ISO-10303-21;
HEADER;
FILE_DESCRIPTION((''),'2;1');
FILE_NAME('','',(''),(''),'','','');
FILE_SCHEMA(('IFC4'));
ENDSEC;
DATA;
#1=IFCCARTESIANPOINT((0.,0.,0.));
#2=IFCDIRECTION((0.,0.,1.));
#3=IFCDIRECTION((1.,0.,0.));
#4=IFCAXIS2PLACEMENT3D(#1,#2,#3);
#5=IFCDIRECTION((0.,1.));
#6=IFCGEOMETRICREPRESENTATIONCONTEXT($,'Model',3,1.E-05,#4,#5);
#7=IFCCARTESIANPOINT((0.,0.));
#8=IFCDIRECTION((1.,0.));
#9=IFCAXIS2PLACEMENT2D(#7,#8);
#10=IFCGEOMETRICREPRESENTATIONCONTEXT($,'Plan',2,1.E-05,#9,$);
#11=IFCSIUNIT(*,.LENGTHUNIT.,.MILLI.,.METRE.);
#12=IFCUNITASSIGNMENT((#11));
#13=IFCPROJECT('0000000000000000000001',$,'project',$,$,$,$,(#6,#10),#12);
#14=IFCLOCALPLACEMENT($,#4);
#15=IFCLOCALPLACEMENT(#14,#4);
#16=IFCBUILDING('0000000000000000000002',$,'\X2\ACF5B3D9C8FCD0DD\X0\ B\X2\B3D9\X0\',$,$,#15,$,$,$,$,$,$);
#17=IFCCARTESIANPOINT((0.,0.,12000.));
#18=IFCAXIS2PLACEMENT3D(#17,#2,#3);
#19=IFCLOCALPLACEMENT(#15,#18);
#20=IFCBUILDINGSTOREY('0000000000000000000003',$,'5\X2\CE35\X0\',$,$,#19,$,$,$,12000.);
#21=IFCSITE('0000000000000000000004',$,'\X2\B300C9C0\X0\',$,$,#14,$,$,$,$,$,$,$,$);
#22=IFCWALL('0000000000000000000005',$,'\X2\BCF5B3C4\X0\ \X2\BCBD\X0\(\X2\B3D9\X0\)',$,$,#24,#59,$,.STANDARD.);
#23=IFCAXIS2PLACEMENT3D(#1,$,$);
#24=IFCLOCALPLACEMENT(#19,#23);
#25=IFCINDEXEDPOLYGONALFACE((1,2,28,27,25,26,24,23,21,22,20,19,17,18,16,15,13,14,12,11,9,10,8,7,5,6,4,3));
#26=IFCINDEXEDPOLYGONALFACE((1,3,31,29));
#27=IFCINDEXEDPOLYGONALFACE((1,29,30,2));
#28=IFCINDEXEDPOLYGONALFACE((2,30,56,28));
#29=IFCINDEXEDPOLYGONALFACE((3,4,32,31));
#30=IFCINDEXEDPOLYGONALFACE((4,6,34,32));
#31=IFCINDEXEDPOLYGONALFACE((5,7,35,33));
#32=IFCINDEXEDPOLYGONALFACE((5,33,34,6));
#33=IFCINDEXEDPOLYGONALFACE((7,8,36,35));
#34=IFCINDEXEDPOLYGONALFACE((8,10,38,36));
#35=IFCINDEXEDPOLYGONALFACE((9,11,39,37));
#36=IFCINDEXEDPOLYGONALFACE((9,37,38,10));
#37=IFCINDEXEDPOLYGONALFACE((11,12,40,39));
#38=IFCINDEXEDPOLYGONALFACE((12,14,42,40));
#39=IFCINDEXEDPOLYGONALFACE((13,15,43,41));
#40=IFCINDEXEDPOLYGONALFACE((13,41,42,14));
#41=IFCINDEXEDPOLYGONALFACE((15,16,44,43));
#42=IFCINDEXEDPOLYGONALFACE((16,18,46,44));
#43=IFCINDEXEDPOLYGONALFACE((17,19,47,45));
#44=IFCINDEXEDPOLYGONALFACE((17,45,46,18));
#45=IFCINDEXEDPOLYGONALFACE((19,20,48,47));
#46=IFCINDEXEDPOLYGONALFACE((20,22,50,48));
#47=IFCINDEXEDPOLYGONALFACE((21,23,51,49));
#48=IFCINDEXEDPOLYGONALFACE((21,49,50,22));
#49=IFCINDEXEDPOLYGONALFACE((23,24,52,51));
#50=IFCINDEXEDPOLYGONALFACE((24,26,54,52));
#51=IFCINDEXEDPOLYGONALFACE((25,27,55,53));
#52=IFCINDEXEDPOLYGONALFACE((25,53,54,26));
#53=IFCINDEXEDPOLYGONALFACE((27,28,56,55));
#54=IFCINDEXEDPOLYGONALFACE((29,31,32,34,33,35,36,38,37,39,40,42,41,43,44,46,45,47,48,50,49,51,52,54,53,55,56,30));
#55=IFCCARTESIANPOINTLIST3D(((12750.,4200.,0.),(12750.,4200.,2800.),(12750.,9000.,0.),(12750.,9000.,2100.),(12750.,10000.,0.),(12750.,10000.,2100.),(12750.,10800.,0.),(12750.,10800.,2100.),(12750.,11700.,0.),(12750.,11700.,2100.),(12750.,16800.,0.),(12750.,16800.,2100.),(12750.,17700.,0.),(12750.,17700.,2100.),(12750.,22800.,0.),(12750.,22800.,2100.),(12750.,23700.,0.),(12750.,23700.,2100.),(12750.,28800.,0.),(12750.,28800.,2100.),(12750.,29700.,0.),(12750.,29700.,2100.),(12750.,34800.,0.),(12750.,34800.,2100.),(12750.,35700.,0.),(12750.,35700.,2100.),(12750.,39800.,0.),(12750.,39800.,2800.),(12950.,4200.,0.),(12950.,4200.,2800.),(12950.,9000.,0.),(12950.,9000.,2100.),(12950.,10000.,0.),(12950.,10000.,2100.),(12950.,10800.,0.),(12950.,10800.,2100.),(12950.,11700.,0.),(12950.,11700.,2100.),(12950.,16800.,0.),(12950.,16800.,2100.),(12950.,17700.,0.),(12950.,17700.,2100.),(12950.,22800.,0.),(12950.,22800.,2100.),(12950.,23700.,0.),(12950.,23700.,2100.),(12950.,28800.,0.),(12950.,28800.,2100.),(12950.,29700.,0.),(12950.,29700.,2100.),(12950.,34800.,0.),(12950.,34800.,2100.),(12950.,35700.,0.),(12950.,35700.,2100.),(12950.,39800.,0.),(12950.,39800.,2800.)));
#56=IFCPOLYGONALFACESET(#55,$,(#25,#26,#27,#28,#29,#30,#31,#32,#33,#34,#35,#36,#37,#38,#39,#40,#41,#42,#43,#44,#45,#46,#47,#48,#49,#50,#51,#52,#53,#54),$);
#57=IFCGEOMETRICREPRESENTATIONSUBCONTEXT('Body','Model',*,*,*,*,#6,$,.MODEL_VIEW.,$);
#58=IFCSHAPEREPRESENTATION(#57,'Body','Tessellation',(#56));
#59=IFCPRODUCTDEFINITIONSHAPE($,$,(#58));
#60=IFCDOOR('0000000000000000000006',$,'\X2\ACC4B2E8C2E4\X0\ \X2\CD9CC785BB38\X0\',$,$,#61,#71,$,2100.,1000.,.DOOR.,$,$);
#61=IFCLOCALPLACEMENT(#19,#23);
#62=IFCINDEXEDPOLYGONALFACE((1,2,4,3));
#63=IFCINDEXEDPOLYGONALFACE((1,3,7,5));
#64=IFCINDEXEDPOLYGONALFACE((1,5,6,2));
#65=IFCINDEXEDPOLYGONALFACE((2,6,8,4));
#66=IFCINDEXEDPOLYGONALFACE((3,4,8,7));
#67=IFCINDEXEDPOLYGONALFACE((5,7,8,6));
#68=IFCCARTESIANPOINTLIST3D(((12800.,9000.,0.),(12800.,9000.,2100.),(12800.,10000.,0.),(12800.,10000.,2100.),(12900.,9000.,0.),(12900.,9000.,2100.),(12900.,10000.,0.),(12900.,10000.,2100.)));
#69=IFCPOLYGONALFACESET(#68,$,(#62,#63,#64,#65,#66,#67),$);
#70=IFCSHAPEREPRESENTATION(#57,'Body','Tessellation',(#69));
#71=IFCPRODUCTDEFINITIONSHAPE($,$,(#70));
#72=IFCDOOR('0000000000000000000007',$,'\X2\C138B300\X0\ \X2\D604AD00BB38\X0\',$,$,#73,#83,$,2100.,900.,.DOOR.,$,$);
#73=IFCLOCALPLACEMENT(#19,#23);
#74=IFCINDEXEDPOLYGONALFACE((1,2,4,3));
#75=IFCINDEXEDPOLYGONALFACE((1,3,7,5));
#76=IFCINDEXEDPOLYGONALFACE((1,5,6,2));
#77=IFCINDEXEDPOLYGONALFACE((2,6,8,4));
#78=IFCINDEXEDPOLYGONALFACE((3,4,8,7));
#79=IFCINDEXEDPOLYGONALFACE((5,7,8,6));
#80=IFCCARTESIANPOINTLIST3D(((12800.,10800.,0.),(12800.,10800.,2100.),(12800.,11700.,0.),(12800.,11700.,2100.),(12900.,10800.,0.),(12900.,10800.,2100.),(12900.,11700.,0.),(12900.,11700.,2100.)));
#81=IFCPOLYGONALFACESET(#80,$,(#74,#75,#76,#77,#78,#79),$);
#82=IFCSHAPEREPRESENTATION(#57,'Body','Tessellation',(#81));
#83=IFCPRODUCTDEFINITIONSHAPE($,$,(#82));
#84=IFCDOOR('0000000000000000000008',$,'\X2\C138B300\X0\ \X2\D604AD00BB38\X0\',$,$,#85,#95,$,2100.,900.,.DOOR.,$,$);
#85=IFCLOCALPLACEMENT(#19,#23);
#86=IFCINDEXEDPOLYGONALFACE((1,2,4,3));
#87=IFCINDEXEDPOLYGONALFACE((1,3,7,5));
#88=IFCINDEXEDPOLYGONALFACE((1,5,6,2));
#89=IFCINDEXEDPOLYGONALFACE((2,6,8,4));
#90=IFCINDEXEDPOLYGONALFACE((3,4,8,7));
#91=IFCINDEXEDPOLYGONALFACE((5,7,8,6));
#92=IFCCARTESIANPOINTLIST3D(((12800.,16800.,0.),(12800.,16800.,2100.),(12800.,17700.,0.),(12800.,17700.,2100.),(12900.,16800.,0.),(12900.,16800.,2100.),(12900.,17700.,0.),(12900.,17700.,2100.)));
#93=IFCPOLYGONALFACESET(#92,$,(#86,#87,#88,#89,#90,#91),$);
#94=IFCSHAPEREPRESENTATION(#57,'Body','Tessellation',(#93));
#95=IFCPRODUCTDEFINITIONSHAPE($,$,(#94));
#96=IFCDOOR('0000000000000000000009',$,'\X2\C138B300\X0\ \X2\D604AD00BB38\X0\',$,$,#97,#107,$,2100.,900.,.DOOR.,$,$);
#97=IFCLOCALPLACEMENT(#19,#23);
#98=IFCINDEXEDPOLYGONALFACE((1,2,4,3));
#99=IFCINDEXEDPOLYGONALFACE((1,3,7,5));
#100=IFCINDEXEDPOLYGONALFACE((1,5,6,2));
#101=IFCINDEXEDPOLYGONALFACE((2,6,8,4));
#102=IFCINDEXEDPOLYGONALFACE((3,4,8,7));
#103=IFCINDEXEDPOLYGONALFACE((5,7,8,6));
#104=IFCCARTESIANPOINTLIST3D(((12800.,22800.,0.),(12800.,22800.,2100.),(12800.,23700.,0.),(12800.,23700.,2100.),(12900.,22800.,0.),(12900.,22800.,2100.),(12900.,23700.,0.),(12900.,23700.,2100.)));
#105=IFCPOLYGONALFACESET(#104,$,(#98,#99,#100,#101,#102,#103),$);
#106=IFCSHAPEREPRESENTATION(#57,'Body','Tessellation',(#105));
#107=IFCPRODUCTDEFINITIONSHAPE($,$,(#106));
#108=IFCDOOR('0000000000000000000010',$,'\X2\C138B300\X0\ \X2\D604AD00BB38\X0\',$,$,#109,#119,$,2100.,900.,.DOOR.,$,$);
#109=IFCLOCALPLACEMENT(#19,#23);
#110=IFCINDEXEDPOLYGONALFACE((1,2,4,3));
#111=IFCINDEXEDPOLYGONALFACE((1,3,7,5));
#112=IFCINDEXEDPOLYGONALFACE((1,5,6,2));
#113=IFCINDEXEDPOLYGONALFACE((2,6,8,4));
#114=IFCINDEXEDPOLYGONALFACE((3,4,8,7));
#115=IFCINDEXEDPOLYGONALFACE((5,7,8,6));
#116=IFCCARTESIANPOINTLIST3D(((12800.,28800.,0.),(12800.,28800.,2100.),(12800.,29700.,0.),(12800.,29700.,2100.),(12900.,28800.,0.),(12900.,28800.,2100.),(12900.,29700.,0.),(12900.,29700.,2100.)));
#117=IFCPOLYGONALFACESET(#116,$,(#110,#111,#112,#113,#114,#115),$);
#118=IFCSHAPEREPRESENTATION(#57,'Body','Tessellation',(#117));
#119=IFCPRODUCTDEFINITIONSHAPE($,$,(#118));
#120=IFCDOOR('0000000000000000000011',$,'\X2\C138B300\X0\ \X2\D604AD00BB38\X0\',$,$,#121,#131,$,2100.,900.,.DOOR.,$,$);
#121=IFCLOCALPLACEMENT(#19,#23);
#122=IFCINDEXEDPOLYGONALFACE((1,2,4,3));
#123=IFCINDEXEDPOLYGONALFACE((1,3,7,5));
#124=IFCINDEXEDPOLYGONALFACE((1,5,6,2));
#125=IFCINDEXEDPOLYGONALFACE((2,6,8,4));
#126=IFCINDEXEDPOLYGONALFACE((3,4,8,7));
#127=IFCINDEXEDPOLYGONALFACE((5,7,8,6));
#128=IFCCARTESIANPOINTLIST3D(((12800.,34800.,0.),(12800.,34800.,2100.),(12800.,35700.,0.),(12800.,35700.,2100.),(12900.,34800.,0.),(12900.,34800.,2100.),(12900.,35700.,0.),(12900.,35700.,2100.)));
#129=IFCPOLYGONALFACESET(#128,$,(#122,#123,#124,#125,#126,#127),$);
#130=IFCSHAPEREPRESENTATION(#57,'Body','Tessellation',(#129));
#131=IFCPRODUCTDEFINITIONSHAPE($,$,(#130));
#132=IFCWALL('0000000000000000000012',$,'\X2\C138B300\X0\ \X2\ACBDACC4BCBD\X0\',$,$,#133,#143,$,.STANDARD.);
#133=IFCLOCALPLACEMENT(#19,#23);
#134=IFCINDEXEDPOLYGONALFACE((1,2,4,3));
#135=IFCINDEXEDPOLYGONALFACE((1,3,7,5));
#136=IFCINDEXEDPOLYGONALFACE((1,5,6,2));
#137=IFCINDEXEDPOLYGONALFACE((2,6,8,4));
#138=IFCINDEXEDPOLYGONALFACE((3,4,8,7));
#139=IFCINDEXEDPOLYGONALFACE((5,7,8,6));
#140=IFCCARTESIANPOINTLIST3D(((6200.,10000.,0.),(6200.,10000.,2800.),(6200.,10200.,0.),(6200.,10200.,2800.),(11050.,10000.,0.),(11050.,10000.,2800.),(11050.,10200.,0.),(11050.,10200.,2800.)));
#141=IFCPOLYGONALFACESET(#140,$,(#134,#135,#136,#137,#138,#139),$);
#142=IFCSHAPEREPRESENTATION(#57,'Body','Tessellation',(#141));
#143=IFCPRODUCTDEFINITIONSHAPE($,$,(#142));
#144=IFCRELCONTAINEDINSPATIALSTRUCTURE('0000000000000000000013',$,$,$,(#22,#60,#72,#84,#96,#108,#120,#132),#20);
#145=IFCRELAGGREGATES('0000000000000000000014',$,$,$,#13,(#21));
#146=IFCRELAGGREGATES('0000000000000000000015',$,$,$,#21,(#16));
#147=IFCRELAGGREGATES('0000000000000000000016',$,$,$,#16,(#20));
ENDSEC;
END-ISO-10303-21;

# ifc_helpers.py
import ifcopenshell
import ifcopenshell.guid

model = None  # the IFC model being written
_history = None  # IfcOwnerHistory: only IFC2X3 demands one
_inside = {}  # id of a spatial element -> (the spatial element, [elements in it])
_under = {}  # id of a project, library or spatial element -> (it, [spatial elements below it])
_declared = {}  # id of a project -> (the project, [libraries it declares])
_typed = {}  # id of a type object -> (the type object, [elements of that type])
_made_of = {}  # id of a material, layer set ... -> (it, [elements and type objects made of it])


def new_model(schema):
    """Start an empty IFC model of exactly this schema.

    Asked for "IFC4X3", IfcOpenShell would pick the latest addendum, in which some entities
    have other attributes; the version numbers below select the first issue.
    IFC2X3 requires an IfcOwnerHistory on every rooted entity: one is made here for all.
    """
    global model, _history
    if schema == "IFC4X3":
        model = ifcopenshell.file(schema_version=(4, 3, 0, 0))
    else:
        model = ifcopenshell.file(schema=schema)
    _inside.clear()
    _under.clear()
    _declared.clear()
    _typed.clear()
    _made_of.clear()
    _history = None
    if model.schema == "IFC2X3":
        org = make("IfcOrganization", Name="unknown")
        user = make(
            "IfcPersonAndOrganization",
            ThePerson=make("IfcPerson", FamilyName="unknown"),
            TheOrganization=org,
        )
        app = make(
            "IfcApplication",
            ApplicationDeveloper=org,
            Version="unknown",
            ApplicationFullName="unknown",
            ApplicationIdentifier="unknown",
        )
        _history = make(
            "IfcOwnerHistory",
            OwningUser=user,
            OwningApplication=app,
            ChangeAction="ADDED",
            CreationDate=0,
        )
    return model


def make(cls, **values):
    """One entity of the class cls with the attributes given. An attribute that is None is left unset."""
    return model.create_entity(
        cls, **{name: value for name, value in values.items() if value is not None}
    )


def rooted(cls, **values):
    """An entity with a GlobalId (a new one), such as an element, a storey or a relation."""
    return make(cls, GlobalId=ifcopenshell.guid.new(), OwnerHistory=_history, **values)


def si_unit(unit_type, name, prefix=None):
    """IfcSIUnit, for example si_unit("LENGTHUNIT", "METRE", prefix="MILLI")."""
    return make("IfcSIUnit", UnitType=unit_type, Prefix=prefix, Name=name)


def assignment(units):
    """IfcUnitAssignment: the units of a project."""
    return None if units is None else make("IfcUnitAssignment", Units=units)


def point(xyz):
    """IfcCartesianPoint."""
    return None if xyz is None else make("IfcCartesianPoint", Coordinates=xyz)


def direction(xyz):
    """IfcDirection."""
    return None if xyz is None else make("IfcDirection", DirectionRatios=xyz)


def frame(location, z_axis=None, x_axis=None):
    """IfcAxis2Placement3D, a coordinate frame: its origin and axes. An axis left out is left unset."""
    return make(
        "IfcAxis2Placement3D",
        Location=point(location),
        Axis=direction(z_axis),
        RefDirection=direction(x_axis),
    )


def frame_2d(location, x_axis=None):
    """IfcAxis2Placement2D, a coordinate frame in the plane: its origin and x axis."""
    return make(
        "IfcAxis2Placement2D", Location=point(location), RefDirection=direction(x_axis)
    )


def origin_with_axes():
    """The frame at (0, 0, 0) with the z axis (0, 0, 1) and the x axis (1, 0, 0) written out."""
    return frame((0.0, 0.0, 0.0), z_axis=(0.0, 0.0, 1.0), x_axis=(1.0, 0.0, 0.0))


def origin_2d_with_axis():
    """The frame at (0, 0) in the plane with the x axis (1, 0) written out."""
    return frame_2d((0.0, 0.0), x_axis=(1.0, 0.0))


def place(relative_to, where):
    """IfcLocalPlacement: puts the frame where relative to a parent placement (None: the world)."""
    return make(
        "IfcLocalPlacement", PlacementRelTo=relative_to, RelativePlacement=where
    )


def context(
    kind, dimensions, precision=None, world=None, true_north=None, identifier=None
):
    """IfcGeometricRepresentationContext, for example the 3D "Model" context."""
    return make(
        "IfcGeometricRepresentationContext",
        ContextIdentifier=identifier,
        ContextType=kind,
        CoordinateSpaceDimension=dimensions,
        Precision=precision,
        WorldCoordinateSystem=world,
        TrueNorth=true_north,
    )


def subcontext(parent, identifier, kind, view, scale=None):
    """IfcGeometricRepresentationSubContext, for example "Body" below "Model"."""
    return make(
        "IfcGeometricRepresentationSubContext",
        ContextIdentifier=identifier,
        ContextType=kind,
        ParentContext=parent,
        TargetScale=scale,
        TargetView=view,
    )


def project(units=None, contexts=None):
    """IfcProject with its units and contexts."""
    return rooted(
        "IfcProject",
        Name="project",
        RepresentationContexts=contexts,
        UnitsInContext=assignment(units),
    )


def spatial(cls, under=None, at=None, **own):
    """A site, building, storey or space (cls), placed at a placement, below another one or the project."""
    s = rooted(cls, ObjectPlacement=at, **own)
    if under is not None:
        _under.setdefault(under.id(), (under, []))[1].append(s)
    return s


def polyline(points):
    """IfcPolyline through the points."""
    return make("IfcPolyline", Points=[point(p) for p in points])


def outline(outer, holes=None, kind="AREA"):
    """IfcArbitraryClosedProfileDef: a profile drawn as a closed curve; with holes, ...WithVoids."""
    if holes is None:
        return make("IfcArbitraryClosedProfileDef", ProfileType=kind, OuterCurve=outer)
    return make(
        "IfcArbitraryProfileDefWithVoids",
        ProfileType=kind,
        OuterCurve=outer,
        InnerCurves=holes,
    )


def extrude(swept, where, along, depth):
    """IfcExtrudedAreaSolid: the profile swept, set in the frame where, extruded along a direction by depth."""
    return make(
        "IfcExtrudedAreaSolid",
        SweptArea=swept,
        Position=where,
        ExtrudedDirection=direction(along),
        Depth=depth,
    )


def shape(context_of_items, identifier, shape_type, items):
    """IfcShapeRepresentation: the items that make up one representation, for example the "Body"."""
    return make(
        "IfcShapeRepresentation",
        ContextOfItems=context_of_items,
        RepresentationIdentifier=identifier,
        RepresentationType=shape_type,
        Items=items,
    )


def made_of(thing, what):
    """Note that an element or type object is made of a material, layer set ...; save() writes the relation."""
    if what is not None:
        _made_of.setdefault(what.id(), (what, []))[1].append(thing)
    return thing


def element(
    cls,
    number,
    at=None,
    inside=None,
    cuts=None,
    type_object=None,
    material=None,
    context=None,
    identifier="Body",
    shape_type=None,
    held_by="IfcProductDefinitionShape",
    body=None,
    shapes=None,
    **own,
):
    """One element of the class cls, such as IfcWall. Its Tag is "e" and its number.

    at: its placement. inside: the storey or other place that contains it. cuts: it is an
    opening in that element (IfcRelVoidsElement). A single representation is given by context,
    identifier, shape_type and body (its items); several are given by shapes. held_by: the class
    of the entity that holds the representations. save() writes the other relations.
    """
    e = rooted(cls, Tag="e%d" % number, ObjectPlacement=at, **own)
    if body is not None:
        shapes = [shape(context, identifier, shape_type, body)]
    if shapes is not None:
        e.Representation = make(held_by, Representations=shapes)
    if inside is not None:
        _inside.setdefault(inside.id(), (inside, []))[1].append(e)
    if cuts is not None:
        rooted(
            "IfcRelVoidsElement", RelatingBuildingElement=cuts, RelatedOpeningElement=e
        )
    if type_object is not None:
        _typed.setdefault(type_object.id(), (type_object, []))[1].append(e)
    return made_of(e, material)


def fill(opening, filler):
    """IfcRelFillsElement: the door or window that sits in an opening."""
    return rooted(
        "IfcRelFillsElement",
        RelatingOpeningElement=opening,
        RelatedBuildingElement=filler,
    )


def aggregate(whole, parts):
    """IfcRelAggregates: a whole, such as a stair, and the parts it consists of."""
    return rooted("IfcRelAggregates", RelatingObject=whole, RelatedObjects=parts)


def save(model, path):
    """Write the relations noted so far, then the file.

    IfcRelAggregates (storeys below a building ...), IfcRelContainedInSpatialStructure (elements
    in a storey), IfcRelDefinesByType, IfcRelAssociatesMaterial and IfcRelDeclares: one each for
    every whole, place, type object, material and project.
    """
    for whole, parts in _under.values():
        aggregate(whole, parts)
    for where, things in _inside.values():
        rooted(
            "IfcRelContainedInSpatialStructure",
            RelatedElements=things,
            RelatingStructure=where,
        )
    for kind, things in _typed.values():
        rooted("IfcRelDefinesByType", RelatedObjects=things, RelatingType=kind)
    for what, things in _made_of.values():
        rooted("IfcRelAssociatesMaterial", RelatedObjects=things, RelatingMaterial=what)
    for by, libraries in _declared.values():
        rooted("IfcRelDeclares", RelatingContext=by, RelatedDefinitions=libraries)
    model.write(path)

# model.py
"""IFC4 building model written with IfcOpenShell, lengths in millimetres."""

from ifc_helpers import new_model, si_unit, direction, frame, origin_with_axes, origin_2d_with_axis, place, context, subcontext, project, spatial, polyline, outline, extrude, element, fill, save


model = new_model("IFC4")

# Units and contexts
model_context = context("Model", 3, precision=1e-05, world=origin_with_axes(), true_north=direction((0.0, 1.0)))
plan_context = context("Plan", 2, precision=1e-05, world=origin_2d_with_axis())
body_context = subcontext(model_context, "Body", "Model", "MODEL_VIEW")
ifc_project = project(units=[si_unit("LENGTHUNIT", "METRE", prefix="MILLI")], contexts=[model_context, plan_context])

# Site, building, storey
site_placement = place(None, origin_with_axes())
site = spatial("IfcSite", under=ifc_project, at=site_placement, Name="대지")
building_placement = place(site_placement, origin_with_axes())
building = spatial("IfcBuilding", under=site, at=building_placement, Name="공동주택 B동")
storey_placement = place(building_placement, frame((0.0, 0.0, 12000.0), z_axis=(0.0, 0.0, 1.0), x_axis=(1.0, 0.0, 0.0)))
storey = spatial("IfcBuildingStorey", under=building, at=storey_placement, Name="5층", Elevation=12000.0)

# Wall, openings, doors
wall_1_placement = place(storey_placement, origin_with_axes())
wall_1 = element("IfcWall", 1, at=wall_1_placement, inside=storey, Name="복도 벽(동)", PredefinedType="STANDARD", context=body_context, shape_type="SweptSolid", body=[
    extrude(outline(polyline([(12750.0, 4200.0), (12750.0, 39800.0), (12950.0, 39800.0), (12950.0, 4200.0), (12750.0, 4200.0)])), origin_with_axes(), (0.0, 0.0, 1.0), 2800.0),
])
opening_1_placement = place(storey_placement, origin_with_axes())
opening_1 = element("IfcOpeningElement", 2, at=opening_1_placement, cuts=wall_1, PredefinedType="OPENING", context=body_context, shape_type="SweptSolid", body=[
    extrude(outline(polyline([(13000.0, 9000.0), (13000.0, 10000.0), (12700.0, 10000.0), (12700.0, 9000.0), (13000.0, 9000.0)])), origin_with_axes(), (0.0, 0.0, 1.0), 2100.0),
])
opening_2_placement = place(storey_placement, origin_with_axes())
opening_2 = element("IfcOpeningElement", 3, at=opening_2_placement, cuts=wall_1, PredefinedType="OPENING", context=body_context, shape_type="SweptSolid", body=[
    extrude(outline(polyline([(13000.0, 10800.0), (13000.0, 11700.0), (12700.0, 11700.0), (12700.0, 10800.0), (13000.0, 10800.0)])), origin_with_axes(), (0.0, 0.0, 1.0), 2100.0),
])
opening_3_placement = place(storey_placement, origin_with_axes())
opening_3 = element("IfcOpeningElement", 4, at=opening_3_placement, cuts=wall_1, PredefinedType="OPENING", context=body_context, shape_type="SweptSolid", body=[
    extrude(outline(polyline([(13000.0, 16800.0), (13000.0, 17700.0), (12700.0, 17700.0), (12700.0, 16800.0), (13000.0, 16800.0)])), origin_with_axes(), (0.0, 0.0, 1.0), 2100.0),
])
opening_4_placement = place(storey_placement, origin_with_axes())
opening_4 = element("IfcOpeningElement", 5, at=opening_4_placement, cuts=wall_1, PredefinedType="OPENING", context=body_context, shape_type="SweptSolid", body=[
    extrude(outline(polyline([(13000.0, 22800.0), (13000.0, 23700.0), (12700.0, 23700.0), (12700.0, 22800.0), (13000.0, 22800.0)])), origin_with_axes(), (0.0, 0.0, 1.0), 2100.0),
])
opening_5_placement = place(storey_placement, origin_with_axes())
opening_5 = element("IfcOpeningElement", 6, at=opening_5_placement, cuts=wall_1, PredefinedType="OPENING", context=body_context, shape_type="SweptSolid", body=[
    extrude(outline(polyline([(13000.0, 28800.0), (13000.0, 29700.0), (12700.0, 29700.0), (12700.0, 28800.0), (13000.0, 28800.0)])), origin_with_axes(), (0.0, 0.0, 1.0), 2100.0),
])
opening_6_placement = place(storey_placement, origin_with_axes())
opening_6 = element("IfcOpeningElement", 7, at=opening_6_placement, cuts=wall_1, PredefinedType="OPENING", context=body_context, shape_type="SweptSolid", body=[
    extrude(outline(polyline([(13000.0, 34800.0), (13000.0, 35700.0), (12700.0, 35700.0), (12700.0, 34800.0), (13000.0, 34800.0)])), origin_with_axes(), (0.0, 0.0, 1.0), 2100.0),
])
door_1_placement = place(storey_placement, origin_with_axes())
door_1 = element("IfcDoor", 8, at=door_1_placement, inside=storey, Name="계단실 출입문", OverallHeight=2100.0, OverallWidth=1000.0, PredefinedType="DOOR", context=body_context, shape_type="SweptSolid", body=[
    extrude(outline(polyline([(12900.0, 9000.0), (12900.0, 10000.0), (12800.0, 10000.0), (12800.0, 9000.0), (12900.0, 9000.0)])), origin_with_axes(), (0.0, 0.0, 1.0), 2100.0),
])
fill(opening_1, door_1)
door_2_placement = place(storey_placement, origin_with_axes())
door_2 = element("IfcDoor", 9, at=door_2_placement, inside=storey, Name="세대 현관문", OverallHeight=2100.0, OverallWidth=900.0, PredefinedType="DOOR", context=body_context, shape_type="SweptSolid", body=[
    extrude(outline(polyline([(12900.0, 10800.0), (12900.0, 11700.0), (12800.0, 11700.0), (12800.0, 10800.0), (12900.0, 10800.0)])), origin_with_axes(), (0.0, 0.0, 1.0), 2100.0),
])
fill(opening_2, door_2)
door_3_placement = place(storey_placement, origin_with_axes())
door_3 = element("IfcDoor", 10, at=door_3_placement, inside=storey, Name="세대 현관문", OverallHeight=2100.0, OverallWidth=900.0, PredefinedType="DOOR", context=body_context, shape_type="SweptSolid", body=[
    extrude(outline(polyline([(12900.0, 16800.0), (12900.0, 17700.0), (12800.0, 17700.0), (12800.0, 16800.0), (12900.0, 16800.0)])), origin_with_axes(), (0.0, 0.0, 1.0), 2100.0),
])
fill(opening_3, door_3)
door_4_placement = place(storey_placement, origin_with_axes())
door_4 = element("IfcDoor", 11, at=door_4_placement, inside=storey, Name="세대 현관문", OverallHeight=2100.0, OverallWidth=900.0, PredefinedType="DOOR", context=body_context, shape_type="SweptSolid", body=[
    extrude(outline(polyline([(12900.0, 22800.0), (12900.0, 23700.0), (12800.0, 23700.0), (12800.0, 22800.0), (12900.0, 22800.0)])), origin_with_axes(), (0.0, 0.0, 1.0), 2100.0),
])
fill(opening_4, door_4)
door_5_placement = place(storey_placement, origin_with_axes())
door_5 = element("IfcDoor", 12, at=door_5_placement, inside=storey, Name="세대 현관문", OverallHeight=2100.0, OverallWidth=900.0, PredefinedType="DOOR", context=body_context, shape_type="SweptSolid", body=[
    extrude(outline(polyline([(12900.0, 28800.0), (12900.0, 29700.0), (12800.0, 29700.0), (12800.0, 28800.0), (12900.0, 28800.0)])), origin_with_axes(), (0.0, 0.0, 1.0), 2100.0),
])
fill(opening_5, door_5)
door_6_placement = place(storey_placement, origin_with_axes())
door_6 = element("IfcDoor", 13, at=door_6_placement, inside=storey, Name="세대 현관문", OverallHeight=2100.0, OverallWidth=900.0, PredefinedType="DOOR", context=body_context, shape_type="SweptSolid", body=[
    extrude(outline(polyline([(12900.0, 34800.0), (12900.0, 35700.0), (12800.0, 35700.0), (12800.0, 34800.0), (12900.0, 34800.0)])), origin_with_axes(), (0.0, 0.0, 1.0), 2100.0),
])
fill(opening_6, door_6)

# Wall
wall_2_placement = place(storey_placement, origin_with_axes())
element("IfcWall", 14, at=wall_2_placement, inside=storey, Name="세대 경계벽", PredefinedType="STANDARD", context=body_context, shape_type="SweptSolid", body=[
    extrude(outline(polyline([(6200.0, 10200.0), (11050.0, 10200.0), (11050.0, 10000.0), (6200.0, 10000.0), (6200.0, 10200.0)])), origin_with_axes(), (0.0, 0.0, 1.0), 2800.0),
])

save(model, "model.ifc")
